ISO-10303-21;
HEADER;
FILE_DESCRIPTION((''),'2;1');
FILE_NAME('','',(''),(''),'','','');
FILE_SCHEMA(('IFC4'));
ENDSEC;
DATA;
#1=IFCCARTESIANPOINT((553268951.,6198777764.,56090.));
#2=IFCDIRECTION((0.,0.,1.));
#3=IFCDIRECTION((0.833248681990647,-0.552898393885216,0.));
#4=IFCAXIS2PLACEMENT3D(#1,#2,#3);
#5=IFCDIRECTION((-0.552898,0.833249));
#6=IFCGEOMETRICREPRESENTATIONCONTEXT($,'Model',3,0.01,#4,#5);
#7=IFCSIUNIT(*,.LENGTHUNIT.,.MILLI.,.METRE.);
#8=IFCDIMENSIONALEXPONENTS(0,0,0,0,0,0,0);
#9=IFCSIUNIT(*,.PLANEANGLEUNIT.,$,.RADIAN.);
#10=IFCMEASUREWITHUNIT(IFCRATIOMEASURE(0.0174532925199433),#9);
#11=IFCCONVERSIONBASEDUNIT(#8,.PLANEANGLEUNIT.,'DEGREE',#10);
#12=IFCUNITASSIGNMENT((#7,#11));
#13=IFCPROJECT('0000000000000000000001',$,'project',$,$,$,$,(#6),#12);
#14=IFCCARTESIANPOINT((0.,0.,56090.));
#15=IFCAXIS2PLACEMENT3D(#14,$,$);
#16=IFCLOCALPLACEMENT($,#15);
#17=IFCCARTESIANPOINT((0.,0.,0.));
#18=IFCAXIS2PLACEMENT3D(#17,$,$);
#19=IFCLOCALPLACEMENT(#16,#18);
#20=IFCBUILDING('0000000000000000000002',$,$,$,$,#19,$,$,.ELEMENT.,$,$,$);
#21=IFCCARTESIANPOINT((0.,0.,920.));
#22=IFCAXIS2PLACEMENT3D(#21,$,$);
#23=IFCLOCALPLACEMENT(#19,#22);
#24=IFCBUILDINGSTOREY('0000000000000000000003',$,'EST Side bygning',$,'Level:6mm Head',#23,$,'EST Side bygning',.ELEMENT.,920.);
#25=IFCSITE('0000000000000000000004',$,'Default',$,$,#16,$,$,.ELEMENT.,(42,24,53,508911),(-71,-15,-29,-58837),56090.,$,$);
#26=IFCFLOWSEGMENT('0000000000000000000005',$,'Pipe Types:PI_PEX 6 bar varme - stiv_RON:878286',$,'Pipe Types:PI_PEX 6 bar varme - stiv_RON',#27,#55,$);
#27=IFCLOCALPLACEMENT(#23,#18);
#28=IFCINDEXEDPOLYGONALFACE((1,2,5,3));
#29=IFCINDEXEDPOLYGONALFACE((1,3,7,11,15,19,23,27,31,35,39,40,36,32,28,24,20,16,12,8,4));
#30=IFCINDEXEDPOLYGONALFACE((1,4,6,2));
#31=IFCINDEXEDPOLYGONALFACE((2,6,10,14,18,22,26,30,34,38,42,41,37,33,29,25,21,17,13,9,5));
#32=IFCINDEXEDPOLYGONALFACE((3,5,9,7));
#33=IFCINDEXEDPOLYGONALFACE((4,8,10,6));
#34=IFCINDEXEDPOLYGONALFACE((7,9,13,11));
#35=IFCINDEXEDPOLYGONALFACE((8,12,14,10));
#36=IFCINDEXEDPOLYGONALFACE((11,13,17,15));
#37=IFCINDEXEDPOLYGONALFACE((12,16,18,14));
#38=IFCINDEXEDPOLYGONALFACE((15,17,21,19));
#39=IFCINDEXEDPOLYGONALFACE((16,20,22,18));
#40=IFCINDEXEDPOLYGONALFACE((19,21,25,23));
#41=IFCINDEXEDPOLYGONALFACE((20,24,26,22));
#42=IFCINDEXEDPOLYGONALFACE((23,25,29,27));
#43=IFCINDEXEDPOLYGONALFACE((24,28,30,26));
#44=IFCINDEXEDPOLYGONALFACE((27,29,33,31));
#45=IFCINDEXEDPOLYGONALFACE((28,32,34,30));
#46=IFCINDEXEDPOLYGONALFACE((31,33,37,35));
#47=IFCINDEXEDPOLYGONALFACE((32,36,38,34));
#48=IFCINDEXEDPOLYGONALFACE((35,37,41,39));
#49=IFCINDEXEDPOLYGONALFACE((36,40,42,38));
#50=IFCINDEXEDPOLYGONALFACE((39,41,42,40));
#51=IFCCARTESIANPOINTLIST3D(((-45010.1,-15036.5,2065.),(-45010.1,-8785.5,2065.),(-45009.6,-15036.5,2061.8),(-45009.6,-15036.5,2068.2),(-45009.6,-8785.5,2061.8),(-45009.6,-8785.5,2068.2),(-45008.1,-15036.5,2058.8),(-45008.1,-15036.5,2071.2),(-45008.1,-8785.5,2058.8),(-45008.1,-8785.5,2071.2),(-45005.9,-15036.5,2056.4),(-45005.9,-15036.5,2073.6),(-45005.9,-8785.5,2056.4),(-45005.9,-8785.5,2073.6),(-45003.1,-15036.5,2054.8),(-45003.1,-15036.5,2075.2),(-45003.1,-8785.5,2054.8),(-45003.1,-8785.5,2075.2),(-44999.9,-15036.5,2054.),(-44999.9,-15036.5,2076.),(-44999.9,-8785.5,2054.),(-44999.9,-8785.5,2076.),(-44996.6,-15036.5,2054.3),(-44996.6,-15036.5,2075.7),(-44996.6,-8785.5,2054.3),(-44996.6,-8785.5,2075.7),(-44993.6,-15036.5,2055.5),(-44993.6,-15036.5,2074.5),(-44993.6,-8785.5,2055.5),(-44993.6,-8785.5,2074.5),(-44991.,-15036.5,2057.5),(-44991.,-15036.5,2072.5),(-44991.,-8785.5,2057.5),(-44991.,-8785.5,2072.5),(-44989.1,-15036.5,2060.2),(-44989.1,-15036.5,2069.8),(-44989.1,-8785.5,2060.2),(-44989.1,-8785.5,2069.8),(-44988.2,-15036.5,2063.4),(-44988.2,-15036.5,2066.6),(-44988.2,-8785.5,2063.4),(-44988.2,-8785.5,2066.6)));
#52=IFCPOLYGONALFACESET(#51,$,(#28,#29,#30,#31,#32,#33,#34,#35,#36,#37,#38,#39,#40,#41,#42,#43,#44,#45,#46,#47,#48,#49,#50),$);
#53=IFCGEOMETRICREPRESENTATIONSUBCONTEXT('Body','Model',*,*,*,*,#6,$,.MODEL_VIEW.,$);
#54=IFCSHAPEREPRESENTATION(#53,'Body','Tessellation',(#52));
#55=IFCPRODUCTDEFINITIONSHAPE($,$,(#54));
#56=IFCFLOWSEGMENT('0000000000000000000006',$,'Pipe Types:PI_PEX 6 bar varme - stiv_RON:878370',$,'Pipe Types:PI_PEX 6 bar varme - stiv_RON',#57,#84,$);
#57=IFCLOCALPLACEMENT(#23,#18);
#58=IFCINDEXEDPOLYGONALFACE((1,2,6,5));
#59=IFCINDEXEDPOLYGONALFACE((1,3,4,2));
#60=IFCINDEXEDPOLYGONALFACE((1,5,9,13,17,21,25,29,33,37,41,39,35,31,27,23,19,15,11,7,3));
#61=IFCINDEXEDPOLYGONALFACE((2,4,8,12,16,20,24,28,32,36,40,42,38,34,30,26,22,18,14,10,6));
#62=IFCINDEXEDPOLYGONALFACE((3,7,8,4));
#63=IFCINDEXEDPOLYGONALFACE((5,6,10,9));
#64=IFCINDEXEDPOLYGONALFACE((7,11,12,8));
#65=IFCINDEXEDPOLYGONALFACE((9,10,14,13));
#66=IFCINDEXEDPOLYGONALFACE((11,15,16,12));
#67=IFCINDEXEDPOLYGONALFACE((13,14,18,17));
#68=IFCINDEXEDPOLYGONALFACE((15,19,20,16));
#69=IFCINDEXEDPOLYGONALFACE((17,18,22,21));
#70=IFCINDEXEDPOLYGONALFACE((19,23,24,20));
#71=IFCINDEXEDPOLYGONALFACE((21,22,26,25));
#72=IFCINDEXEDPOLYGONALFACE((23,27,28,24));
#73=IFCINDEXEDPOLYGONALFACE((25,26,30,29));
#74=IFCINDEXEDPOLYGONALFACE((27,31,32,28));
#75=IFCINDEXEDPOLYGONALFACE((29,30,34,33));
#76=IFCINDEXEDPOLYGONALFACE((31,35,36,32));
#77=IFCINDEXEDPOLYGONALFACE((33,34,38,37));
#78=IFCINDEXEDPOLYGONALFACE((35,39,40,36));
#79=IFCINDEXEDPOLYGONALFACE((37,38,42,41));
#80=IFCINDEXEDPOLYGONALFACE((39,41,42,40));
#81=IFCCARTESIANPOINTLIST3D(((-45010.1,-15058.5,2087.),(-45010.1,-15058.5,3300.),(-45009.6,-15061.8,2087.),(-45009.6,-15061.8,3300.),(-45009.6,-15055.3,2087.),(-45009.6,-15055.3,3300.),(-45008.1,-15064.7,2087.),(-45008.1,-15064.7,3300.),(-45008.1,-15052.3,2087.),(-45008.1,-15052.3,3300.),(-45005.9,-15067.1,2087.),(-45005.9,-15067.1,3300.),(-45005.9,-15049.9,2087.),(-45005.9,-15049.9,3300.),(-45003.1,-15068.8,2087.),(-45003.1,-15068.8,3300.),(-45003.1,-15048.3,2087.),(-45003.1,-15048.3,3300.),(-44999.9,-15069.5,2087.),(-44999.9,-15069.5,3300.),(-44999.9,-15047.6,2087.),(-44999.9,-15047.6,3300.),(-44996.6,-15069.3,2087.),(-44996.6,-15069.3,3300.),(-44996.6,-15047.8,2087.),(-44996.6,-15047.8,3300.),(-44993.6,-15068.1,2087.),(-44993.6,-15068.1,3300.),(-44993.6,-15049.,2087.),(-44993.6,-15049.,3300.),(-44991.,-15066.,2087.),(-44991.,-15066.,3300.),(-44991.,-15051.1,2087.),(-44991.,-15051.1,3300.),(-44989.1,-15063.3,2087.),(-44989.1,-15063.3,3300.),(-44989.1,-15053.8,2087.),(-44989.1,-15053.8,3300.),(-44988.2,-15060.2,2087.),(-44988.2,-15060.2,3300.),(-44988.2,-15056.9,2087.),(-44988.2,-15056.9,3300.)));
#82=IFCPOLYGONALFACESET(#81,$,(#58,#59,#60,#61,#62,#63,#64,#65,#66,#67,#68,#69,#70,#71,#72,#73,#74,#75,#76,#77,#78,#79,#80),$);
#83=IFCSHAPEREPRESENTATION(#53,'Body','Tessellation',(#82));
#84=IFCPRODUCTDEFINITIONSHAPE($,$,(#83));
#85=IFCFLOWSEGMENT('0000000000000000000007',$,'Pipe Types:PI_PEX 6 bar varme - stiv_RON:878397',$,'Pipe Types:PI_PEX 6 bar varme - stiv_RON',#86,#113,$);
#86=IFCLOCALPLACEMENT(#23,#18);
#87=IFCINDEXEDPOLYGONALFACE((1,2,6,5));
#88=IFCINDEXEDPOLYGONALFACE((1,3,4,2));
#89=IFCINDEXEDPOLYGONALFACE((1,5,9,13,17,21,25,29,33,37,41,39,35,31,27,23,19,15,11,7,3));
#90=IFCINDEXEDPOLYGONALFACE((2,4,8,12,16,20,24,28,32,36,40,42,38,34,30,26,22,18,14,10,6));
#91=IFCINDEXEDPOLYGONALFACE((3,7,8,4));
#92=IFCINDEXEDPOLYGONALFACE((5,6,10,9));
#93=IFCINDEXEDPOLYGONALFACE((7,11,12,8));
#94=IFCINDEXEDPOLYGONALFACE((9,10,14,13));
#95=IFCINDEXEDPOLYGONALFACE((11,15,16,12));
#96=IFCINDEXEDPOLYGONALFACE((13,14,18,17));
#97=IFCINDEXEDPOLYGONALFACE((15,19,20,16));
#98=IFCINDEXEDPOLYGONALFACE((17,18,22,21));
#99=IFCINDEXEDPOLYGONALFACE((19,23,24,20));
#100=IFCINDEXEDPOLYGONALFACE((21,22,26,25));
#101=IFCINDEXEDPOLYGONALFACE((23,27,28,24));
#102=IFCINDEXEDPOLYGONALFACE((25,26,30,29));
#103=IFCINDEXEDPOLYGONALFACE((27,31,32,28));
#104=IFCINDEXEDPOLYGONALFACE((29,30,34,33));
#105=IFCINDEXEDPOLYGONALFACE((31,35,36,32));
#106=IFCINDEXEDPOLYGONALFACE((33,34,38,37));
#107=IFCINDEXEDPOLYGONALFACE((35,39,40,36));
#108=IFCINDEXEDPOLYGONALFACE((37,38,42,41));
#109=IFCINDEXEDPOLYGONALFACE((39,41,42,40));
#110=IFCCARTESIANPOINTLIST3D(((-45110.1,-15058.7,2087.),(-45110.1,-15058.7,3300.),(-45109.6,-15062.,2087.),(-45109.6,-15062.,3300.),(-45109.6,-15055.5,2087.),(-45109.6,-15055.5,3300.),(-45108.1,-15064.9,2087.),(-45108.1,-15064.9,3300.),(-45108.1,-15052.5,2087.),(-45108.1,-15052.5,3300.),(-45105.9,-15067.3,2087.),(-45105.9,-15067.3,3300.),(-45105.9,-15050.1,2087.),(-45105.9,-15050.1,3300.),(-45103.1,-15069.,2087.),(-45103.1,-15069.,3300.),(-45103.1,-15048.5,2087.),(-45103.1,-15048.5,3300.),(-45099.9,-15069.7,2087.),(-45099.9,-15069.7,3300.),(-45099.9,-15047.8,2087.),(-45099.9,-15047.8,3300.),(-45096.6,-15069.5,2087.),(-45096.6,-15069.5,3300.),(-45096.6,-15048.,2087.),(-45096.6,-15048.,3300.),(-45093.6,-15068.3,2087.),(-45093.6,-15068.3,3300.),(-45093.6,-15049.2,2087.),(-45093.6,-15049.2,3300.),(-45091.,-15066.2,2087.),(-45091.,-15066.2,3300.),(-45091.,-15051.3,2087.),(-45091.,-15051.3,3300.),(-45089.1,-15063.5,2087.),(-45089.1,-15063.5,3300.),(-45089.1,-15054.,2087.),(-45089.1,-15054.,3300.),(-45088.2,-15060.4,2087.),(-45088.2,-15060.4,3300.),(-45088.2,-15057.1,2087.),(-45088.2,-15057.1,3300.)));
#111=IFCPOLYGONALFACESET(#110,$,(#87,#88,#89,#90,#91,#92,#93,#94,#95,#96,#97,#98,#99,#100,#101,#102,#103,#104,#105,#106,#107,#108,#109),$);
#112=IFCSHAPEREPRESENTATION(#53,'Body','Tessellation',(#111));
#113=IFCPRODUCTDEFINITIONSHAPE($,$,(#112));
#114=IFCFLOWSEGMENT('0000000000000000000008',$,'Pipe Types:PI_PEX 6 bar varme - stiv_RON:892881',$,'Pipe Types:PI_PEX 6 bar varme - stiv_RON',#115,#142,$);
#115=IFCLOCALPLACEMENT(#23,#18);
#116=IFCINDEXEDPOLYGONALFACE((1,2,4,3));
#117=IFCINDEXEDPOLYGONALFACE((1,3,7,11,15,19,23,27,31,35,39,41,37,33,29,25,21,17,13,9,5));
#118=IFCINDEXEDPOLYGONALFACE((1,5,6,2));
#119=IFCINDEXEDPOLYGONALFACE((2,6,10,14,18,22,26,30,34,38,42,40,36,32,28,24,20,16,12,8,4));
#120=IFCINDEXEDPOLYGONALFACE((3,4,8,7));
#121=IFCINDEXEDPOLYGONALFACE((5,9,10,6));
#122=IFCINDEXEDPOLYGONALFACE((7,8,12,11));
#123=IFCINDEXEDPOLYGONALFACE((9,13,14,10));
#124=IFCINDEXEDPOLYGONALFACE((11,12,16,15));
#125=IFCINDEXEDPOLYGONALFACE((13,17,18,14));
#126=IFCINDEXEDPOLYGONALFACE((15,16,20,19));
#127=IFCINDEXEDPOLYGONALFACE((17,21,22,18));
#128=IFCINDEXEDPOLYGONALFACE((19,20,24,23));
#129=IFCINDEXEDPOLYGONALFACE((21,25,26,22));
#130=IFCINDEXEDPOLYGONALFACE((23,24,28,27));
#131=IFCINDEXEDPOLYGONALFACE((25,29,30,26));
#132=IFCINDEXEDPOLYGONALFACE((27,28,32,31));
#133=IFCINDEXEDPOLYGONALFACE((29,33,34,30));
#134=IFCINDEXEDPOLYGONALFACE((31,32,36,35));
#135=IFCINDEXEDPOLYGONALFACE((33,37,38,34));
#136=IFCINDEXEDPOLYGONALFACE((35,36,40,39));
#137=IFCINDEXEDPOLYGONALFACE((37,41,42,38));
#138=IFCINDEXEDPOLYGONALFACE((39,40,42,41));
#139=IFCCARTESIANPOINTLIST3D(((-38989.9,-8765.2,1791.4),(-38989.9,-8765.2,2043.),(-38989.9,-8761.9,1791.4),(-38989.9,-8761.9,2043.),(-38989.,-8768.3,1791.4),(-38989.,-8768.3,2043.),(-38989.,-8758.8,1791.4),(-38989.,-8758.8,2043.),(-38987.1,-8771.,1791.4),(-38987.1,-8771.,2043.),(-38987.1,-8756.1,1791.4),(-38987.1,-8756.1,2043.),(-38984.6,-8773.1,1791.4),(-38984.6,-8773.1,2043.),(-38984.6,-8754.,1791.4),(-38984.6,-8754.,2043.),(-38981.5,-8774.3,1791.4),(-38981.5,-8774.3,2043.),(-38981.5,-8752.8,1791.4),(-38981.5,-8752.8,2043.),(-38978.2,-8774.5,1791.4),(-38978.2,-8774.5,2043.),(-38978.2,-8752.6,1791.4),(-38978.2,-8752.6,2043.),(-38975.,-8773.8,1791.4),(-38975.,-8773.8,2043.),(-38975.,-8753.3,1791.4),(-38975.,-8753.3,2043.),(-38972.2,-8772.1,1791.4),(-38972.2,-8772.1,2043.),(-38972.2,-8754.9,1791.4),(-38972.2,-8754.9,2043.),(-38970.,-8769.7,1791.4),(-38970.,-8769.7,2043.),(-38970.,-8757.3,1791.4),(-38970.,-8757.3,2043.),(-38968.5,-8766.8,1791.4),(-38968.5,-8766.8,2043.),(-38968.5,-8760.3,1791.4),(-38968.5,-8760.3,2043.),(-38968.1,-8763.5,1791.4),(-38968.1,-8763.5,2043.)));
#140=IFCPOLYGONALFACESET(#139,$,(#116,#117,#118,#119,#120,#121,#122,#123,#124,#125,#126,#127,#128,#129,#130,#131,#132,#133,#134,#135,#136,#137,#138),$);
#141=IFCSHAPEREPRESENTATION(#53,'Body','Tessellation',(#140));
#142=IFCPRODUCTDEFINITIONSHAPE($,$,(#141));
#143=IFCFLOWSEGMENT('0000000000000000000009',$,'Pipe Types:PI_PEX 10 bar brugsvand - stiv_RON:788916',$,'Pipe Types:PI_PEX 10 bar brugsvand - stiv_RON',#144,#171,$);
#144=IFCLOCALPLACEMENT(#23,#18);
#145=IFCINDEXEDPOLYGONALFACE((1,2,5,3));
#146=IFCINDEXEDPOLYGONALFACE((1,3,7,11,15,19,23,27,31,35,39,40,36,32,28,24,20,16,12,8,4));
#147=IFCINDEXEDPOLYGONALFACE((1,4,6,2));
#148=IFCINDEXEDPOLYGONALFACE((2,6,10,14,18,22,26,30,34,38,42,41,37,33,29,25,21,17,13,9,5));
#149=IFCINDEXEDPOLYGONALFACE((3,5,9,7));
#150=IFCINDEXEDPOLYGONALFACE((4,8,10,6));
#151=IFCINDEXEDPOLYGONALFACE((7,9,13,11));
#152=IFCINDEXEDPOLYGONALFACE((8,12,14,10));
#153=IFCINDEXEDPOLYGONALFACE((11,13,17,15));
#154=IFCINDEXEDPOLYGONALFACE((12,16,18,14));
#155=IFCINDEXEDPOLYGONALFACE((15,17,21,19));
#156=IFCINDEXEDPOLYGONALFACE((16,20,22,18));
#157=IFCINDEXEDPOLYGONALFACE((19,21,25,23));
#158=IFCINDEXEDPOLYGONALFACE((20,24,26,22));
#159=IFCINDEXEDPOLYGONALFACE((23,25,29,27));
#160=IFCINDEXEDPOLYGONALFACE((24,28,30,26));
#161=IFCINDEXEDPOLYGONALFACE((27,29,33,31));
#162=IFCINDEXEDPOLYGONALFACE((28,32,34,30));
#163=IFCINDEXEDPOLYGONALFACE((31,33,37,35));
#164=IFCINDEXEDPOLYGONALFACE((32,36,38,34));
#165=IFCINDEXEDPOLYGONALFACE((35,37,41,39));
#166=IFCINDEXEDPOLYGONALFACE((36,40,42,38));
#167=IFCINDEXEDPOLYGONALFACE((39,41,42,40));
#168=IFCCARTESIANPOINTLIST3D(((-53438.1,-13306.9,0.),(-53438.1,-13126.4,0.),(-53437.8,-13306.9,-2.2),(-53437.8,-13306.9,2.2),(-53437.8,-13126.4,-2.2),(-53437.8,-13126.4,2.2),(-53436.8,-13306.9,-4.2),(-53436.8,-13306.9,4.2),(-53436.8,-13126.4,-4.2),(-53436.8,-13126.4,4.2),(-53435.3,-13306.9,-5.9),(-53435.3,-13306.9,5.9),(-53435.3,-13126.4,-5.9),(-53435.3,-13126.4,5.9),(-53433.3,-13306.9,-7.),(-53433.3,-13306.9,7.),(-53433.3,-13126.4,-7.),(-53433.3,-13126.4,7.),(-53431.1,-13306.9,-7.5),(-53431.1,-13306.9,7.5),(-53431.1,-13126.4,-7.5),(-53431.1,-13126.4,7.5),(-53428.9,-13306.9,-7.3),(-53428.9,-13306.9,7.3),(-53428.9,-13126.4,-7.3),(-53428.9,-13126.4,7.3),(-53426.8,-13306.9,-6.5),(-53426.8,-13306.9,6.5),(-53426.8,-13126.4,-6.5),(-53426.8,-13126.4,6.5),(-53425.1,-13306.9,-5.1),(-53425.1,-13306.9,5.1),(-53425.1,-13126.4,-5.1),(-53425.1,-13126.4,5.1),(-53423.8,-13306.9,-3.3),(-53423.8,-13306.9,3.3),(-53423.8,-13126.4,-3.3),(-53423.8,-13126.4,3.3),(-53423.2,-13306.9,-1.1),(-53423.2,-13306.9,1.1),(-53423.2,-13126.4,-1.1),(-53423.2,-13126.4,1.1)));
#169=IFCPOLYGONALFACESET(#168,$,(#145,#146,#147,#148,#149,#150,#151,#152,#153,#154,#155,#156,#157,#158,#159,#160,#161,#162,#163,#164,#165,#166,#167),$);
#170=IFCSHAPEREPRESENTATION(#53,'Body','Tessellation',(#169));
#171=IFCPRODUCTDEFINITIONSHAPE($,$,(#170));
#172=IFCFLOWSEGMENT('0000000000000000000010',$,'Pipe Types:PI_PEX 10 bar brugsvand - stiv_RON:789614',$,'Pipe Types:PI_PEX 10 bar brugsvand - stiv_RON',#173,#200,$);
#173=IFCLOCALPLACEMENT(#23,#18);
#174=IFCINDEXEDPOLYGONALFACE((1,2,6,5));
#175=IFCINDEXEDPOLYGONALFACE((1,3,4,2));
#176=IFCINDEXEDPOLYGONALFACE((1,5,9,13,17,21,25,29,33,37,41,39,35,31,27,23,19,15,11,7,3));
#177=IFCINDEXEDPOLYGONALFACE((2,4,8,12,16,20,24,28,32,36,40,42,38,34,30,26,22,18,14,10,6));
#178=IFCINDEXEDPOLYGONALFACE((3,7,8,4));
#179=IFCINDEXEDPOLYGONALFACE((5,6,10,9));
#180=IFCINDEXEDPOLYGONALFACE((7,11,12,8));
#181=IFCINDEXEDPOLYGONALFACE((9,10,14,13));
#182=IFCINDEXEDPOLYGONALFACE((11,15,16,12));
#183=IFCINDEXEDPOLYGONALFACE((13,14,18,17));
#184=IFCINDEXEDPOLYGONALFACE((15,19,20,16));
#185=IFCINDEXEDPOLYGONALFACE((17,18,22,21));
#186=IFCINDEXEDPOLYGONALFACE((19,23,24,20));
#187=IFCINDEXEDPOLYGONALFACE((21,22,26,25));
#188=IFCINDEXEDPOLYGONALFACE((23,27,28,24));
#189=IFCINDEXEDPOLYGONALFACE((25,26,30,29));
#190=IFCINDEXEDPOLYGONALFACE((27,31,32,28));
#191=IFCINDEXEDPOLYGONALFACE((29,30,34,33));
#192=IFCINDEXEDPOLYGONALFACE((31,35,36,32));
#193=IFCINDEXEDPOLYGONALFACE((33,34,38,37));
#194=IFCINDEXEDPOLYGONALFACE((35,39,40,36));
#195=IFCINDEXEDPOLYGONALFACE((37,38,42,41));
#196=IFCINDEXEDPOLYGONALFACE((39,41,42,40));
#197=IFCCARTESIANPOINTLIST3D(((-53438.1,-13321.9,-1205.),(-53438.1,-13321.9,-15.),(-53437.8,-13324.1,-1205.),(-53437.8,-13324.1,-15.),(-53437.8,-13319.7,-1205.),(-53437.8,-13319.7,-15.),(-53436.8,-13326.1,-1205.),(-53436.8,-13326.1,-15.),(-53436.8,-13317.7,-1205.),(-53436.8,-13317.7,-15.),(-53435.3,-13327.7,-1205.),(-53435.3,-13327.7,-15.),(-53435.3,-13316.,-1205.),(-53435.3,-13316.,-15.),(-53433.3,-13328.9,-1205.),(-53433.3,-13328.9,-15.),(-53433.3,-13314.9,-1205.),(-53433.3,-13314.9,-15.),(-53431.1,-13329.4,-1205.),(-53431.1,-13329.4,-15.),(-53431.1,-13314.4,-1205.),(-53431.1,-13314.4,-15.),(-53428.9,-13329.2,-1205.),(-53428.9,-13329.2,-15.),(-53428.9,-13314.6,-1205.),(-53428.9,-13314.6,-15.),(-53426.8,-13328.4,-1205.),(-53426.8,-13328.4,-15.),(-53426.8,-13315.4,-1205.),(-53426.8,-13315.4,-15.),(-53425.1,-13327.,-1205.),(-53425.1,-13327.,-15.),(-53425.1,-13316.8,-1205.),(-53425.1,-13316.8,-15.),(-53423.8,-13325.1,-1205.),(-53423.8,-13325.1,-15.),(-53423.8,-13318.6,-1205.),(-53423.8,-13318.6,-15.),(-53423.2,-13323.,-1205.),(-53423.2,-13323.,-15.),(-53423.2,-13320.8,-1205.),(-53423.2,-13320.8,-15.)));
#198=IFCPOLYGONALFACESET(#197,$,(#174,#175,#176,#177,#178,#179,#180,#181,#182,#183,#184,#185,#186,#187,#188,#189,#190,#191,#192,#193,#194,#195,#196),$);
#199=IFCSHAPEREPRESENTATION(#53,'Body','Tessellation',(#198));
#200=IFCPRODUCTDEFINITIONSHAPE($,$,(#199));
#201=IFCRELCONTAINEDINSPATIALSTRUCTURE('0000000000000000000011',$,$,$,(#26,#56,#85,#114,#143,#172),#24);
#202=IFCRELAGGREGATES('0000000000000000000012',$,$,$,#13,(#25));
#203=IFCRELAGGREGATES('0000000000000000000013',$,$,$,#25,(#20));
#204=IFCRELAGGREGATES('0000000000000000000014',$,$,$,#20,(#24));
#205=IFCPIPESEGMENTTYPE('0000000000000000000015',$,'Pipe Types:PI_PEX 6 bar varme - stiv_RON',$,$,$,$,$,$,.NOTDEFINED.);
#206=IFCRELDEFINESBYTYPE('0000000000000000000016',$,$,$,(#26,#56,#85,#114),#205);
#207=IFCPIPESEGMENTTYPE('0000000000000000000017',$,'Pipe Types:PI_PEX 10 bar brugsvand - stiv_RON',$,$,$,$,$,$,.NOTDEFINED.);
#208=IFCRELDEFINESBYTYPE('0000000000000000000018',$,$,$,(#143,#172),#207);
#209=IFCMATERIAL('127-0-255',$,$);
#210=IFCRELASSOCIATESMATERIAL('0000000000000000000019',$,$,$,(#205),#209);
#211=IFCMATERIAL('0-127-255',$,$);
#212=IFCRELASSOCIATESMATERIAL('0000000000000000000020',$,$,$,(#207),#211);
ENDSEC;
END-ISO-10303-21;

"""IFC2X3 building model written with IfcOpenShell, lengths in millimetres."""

from ifc_helpers import new_model, entity, si_unit, converted_unit, direction, frame, frame_2d, origin, origin_2d_with_axis, place, context, subcontext, project, spatial, circle, extrude, material, type_object, element, save


model = new_model("IFC2X3")

# Units and contexts
model_context = context("Model", 3, precision=0.01, world=frame((553268951.0, 6198777764.0, 56090.0), z_axis=(0.0, 0.0, 1.0), x_axis=(0.833248681990647, -0.552898393885216, 0.0)), true_north=direction((-0.552898, 0.833249)))
body_context = subcontext(model_context, "Body", "Model", "MODEL_VIEW")
ifc_project = project(units=[si_unit("LENGTHUNIT", "METRE", prefix="MILLI"), converted_unit("PLANEANGLEUNIT", "DEGREE", entity("IfcRatioMeasure", 0.0174532925199433), si_unit("PLANEANGLEUNIT", "RADIAN"), dimensions=[0, 0, 0, 0, 0, 0, 0])], contexts=[model_context])

# Site, building, storey
site_placement = place(None, frame((0.0, 0.0, 56090.0)))
site = spatial("IfcSite", under=ifc_project, at=site_placement, Name="Default", CompositionType="ELEMENT", RefLatitude=(42, 24, 53, 508911), RefLongitude=(-71, -15, -29, -58837), RefElevation=56090.0)
building_placement = place(site_placement, origin())
building = spatial("IfcBuilding", under=site, at=building_placement, CompositionType="ELEMENT")
storey_placement = place(building_placement, frame((0.0, 0.0, 920.0)))
storey = spatial("IfcBuildingStorey", under=building, at=storey_placement, Name="EST Side bygning", ObjectType="Level:6mm Head", LongName="EST Side bygning", CompositionType="ELEMENT", Elevation=920.0)

# Flow segments
ifc_material_1 = material(Name="127-0-255")
pipe_segment_type_1 = type_object("IfcPipeSegmentType", Name="Pipe Types:PI_PEX 6 bar varme - stiv_RON", PredefinedType="NOTDEFINED", material=ifc_material_1)
flow_segment_1_placement = place(storey_placement, origin())
element("IfcFlowSegment", 1, at=flow_segment_1_placement, inside=storey, type_object=pipe_segment_type_1, Name="Pipe Types:PI_PEX 6 bar varme - stiv_RON:878286", ObjectType="Pipe Types:PI_PEX 6 bar varme - stiv_RON", context=body_context, shape_type="SweptSolid", body=[
    extrude(circle(Radius=11.0, at=origin_2d_with_axis()), frame((-44999.1, -15036.5, 2065.0), z_axis=(0.0, 1.0, 0.0), x_axis=(-1.0, 0.0, 0.0)), (0.0, 0.0, 1.0), 6251.0),
])
flow_segment_2_placement = place(storey_placement, origin())
element("IfcFlowSegment", 2, at=flow_segment_2_placement, inside=storey, type_object=pipe_segment_type_1, Name="Pipe Types:PI_PEX 6 bar varme - stiv_RON:878370", ObjectType="Pipe Types:PI_PEX 6 bar varme - stiv_RON", context=body_context, shape_type="SweptSolid", body=[
    extrude(circle(Radius=11.0, at=origin_2d_with_axis()), frame((-44999.1, -15058.5, 2087.0), z_axis=(0.0, 0.0, 1.0), x_axis=(-1.0, 0.0, 0.0)), (0.0, 0.0, 1.0), 1213.0),
])
flow_segment_3_placement = place(storey_placement, origin())
element("IfcFlowSegment", 3, at=flow_segment_3_placement, inside=storey, type_object=pipe_segment_type_1, Name="Pipe Types:PI_PEX 6 bar varme - stiv_RON:878397", ObjectType="Pipe Types:PI_PEX 6 bar varme - stiv_RON", context=body_context, shape_type="SweptSolid", body=[
    extrude(circle(Radius=11.0, at=origin_2d_with_axis()), frame((-45099.1, -15058.7, 2087.0), z_axis=(0.0, 0.0, 1.0), x_axis=(-1.0, 0.0, 0.0)), (0.0, 0.0, 1.0), 1213.0),
])
flow_segment_4_placement = place(storey_placement, origin())
element("IfcFlowSegment", 4, at=flow_segment_4_placement, inside=storey, type_object=pipe_segment_type_1, Name="Pipe Types:PI_PEX 6 bar varme - stiv_RON:892881", ObjectType="Pipe Types:PI_PEX 6 bar varme - stiv_RON", context=body_context, shape_type="SweptSolid", body=[
    extrude(circle(Radius=11.0, at=frame_2d((0.0, 0.0), x_axis=(1.0, 0.0))), frame((-38979.1, -8763.5, 1791.4)), (0.0, 0.0, 1.0), 251.6),
])
ifc_material_2 = material(Name="0-127-255")
pipe_segment_type_2 = type_object("IfcPipeSegmentType", Name="Pipe Types:PI_PEX 10 bar brugsvand - stiv_RON", PredefinedType="NOTDEFINED", material=ifc_material_2)
flow_segment_5_placement = place(storey_placement, origin())
element("IfcFlowSegment", 5, at=flow_segment_5_placement, inside=storey, type_object=pipe_segment_type_2, Name="Pipe Types:PI_PEX 10 bar brugsvand - stiv_RON:788916", ObjectType="Pipe Types:PI_PEX 10 bar brugsvand - stiv_RON", context=body_context, shape_type="SweptSolid", body=[
    extrude(circle(Radius=7.5, at=frame_2d((0.0, 0.0), x_axis=(1.0, 0.0))), frame((-53430.6, -13306.9, 0.0), z_axis=(0.0, 1.0, 0.0), x_axis=(-1.0, 0.0, 0.0)), (0.0, 0.0, 1.0), 180.5),
])
flow_segment_6_placement = place(storey_placement, origin())
element("IfcFlowSegment", 6, at=flow_segment_6_placement, inside=storey, type_object=pipe_segment_type_2, Name="Pipe Types:PI_PEX 10 bar brugsvand - stiv_RON:789614", ObjectType="Pipe Types:PI_PEX 10 bar brugsvand - stiv_RON", context=body_context, shape_type="SweptSolid", body=[
    extrude(circle(Radius=7.5, at=frame_2d((0.0, 0.0), x_axis=(1.0, 0.0))), frame((-53430.6, -13321.9, -1205.0), z_axis=(0.0, 0.0, 1.0), x_axis=(-1.0, 0.0, 0.0)), (0.0, 0.0, 1.0), 1190.0),
])

save(model, "model.ifc")
